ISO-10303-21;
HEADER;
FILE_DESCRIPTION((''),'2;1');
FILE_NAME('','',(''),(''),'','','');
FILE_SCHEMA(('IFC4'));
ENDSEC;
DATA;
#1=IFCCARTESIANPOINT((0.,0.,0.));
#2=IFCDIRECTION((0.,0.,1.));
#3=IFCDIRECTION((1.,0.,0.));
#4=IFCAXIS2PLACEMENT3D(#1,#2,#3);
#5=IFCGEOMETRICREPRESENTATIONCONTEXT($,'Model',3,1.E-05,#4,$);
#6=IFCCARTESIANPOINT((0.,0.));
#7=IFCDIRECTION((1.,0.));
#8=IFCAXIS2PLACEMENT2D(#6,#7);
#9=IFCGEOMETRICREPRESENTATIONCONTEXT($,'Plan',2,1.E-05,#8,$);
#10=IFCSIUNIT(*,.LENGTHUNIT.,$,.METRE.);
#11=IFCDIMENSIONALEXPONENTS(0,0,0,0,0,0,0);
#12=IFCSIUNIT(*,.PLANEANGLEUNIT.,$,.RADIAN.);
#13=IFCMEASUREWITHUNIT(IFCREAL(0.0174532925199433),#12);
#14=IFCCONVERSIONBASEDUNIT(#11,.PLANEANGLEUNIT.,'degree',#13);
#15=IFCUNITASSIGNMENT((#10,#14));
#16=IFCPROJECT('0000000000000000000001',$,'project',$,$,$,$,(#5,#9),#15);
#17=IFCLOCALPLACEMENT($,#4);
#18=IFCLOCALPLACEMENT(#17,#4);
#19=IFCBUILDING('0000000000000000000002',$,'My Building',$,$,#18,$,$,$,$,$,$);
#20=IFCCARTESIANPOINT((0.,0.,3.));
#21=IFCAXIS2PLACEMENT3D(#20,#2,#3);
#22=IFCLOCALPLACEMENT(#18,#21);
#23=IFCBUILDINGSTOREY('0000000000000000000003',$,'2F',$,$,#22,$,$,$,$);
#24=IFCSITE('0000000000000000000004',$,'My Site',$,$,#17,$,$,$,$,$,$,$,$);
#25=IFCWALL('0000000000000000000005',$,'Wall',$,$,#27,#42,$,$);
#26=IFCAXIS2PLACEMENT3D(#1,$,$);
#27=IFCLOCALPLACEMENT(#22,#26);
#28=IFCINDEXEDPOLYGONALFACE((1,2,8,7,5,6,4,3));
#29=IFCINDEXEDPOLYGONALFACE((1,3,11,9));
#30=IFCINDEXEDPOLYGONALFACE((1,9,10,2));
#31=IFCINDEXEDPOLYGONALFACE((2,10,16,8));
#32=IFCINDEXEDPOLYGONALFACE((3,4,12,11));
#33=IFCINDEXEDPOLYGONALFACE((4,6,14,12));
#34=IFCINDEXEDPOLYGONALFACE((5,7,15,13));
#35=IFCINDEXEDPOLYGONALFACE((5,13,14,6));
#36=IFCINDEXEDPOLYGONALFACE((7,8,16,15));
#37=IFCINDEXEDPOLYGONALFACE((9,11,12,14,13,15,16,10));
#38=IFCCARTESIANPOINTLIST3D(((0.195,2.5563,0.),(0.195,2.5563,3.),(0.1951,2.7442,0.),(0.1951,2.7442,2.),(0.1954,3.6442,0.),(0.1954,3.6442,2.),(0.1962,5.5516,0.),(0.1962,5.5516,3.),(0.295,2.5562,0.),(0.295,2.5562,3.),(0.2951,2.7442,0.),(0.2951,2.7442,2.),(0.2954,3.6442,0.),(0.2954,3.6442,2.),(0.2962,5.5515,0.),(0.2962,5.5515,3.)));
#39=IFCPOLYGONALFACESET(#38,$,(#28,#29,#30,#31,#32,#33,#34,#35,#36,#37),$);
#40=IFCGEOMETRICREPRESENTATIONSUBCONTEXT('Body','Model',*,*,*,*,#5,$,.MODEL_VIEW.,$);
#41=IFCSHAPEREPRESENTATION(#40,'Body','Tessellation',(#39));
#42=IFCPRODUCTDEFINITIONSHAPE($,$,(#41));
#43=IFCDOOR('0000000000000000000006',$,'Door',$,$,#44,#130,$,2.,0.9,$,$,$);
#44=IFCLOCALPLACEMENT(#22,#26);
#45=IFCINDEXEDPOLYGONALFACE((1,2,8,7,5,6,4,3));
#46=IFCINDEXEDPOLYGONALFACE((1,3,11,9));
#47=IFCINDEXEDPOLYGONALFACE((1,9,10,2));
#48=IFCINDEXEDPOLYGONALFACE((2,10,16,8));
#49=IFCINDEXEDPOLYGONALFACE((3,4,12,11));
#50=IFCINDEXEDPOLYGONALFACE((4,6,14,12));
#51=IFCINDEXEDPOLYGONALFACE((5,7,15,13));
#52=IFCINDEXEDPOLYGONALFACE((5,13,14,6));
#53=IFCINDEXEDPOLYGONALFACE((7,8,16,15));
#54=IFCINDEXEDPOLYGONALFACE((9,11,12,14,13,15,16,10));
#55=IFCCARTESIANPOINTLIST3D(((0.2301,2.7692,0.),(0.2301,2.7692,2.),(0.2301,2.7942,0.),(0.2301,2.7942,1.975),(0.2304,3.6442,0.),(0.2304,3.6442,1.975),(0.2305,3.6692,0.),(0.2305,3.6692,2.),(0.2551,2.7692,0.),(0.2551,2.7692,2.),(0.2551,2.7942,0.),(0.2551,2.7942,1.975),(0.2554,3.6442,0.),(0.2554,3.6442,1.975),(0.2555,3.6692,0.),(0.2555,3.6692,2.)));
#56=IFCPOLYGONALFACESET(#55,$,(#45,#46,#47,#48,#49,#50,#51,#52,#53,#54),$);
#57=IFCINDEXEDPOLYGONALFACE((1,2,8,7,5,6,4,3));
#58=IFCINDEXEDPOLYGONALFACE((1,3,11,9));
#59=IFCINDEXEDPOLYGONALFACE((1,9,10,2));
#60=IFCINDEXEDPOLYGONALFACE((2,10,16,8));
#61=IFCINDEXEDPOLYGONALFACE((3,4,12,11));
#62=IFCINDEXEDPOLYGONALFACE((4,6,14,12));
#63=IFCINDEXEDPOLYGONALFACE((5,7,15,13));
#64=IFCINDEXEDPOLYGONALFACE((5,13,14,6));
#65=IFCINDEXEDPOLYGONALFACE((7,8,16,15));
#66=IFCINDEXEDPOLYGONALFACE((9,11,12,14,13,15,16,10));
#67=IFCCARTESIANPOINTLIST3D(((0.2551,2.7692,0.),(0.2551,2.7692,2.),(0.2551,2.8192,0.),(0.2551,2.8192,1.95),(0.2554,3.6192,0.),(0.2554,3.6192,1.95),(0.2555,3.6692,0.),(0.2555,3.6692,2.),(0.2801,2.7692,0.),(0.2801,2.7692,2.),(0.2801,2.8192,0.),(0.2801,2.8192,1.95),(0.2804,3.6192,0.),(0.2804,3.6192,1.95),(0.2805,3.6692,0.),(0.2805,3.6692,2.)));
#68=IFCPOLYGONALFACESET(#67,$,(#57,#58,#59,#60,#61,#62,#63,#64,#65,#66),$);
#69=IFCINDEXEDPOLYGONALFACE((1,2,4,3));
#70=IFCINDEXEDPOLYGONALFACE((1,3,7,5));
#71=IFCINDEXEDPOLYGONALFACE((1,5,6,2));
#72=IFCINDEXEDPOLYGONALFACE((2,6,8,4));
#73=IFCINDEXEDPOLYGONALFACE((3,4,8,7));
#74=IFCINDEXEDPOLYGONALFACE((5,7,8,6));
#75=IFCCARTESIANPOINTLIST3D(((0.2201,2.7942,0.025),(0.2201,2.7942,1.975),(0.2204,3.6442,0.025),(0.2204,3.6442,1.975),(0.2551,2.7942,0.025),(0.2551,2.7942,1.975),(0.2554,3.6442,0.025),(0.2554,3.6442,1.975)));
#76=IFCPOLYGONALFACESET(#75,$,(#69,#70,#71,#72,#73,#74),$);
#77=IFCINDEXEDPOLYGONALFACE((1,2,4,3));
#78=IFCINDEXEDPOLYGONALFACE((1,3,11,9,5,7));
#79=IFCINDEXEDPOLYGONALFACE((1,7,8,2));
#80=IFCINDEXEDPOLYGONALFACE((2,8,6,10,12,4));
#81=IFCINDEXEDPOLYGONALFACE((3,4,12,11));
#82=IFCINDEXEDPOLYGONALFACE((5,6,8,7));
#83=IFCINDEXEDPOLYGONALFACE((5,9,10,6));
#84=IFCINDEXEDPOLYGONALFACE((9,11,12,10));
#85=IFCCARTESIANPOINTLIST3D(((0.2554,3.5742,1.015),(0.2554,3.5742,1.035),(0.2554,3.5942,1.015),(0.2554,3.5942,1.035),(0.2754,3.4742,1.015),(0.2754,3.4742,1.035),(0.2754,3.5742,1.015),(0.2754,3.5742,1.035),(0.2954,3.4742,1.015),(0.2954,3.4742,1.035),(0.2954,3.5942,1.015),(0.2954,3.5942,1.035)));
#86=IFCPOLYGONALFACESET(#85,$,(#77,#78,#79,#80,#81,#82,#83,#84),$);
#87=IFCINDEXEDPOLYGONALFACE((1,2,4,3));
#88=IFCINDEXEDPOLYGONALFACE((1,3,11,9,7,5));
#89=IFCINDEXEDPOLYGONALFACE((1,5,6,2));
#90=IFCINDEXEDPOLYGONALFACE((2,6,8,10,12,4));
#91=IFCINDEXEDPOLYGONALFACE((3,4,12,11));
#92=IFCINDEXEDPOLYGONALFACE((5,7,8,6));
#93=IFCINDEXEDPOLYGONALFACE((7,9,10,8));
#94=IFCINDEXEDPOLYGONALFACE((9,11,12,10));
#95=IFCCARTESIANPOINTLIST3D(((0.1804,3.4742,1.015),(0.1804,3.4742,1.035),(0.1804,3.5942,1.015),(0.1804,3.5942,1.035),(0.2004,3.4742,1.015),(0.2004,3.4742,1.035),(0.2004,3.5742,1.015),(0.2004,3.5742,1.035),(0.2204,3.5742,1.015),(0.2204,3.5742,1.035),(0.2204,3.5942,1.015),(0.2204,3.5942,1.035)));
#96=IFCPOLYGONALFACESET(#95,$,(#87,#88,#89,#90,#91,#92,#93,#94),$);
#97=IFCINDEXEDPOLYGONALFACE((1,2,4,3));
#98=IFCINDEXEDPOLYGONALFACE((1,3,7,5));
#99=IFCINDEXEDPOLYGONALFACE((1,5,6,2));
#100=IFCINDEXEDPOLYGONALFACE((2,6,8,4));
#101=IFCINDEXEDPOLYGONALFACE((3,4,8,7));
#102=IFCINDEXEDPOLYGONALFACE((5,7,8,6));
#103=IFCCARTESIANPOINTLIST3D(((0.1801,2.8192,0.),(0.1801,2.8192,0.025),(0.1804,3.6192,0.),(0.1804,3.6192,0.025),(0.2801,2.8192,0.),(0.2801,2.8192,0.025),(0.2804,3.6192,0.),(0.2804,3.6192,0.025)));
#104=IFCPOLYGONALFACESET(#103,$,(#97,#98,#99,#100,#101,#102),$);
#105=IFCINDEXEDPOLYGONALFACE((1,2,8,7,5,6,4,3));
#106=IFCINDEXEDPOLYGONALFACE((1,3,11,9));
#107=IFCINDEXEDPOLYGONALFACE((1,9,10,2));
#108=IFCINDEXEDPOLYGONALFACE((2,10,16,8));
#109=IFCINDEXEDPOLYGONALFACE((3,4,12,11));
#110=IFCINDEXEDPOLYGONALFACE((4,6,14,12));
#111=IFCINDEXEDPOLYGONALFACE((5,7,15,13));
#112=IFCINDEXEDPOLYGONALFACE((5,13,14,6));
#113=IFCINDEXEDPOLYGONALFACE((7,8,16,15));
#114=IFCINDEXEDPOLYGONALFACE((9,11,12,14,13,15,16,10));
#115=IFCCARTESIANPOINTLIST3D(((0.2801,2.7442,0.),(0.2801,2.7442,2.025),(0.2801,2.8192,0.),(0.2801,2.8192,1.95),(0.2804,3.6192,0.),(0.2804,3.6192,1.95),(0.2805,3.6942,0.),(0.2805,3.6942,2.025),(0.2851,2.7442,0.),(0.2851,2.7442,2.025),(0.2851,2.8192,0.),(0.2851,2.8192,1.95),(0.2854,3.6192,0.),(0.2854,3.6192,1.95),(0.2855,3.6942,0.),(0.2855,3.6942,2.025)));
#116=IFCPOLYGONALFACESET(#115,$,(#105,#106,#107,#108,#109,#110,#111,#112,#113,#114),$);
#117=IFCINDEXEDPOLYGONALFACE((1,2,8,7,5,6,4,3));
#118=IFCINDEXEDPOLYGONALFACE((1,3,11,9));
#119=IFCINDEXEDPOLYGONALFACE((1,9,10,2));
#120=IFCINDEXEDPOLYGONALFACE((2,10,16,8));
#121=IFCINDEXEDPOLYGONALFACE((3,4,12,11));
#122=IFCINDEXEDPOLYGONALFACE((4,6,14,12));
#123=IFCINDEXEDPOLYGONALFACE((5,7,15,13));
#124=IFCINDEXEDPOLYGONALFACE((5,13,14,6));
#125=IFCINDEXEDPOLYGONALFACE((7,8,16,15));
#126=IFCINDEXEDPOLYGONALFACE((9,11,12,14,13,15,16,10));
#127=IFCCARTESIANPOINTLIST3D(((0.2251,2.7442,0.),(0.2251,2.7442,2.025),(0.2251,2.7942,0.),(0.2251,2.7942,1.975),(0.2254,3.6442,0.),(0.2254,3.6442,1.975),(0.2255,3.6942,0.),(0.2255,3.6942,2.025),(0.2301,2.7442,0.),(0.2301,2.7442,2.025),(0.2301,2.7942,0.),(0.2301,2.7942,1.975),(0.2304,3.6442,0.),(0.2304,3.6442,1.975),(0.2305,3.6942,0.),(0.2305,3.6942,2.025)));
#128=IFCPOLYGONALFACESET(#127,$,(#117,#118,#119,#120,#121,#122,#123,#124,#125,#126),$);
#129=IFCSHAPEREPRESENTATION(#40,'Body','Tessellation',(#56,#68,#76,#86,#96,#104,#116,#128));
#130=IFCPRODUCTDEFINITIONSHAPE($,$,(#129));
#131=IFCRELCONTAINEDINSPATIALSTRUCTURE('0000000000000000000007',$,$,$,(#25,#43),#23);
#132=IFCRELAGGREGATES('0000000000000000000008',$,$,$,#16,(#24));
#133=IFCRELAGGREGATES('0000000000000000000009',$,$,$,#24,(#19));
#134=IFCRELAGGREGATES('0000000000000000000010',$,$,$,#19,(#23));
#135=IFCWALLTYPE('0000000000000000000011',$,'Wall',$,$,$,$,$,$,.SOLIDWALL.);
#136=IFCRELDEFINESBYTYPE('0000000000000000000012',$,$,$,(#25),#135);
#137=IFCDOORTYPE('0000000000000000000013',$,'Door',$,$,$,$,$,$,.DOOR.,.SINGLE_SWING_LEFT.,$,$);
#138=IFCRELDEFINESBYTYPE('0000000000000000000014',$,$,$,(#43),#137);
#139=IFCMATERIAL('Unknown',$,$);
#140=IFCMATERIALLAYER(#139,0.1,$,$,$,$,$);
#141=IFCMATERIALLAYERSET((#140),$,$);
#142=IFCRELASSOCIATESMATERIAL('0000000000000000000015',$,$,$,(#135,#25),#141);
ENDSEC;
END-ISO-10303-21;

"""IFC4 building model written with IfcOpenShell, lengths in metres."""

from ifc_helpers import new_model, entity, si_unit, converted_unit, frame, origin_with_axes, origin_2d_with_axis, place, context, subcontext, project, spatial, line, indexed_curve, outline, extrude, shape, source, transform, mapped, material, layer, layer_set, layer_usage, type_object, type_shapes, element, fill, save


model = new_model("IFC4")

# Units and contexts
model_context = context("Model", 3, precision=1e-05, world=origin_with_axes())
plan_context = context("Plan", 2, precision=1e-05, world=origin_2d_with_axis())
body_context_1 = subcontext(model_context, "Body", "Model", "MODEL_VIEW")
body_context_2 = subcontext(plan_context, "Body", "Plan", "PLAN_VIEW")
ifc_project = project(units=[si_unit("LENGTHUNIT", "METRE"), converted_unit("PLANEANGLEUNIT", "degree", entity("IfcReal", 0.0174532925199433), si_unit("PLANEANGLEUNIT", "RADIAN"), dimensions=[0, 0, 0, 0, 0, 0, 0])], contexts=[model_context, plan_context])

# Site, building, storey
site_placement = place(None, origin_with_axes())
site = spatial("IfcSite", under=ifc_project, at=site_placement, Name="My Site")
building_placement = place(site_placement, origin_with_axes())
building = spatial("IfcBuilding", under=site, at=building_placement, Name="My Building")
storey_placement = place(building_placement, frame((0.0, 0.0, 3.0), z_axis=(0.0, 0.0, 1.0), x_axis=(1.0, 0.0, 0.0)))
storey = spatial("IfcBuildingStorey", under=building, at=storey_placement, Name="2F")

# Shared definitions
ifc_material = material(Name="Unknown")
ifc_layer = layer(ifc_material, 0.1)
ifc_layer_set = layer_set([ifc_layer])
wall_type = type_object("IfcWallType", Name="Wall", PredefinedType="SOLIDWALL", material=ifc_layer_set)

# Wall, opening, door
ifc_layer_usage_1 = layer_usage(ifc_layer_set, "AXIS2", "POSITIVE", 0.0)
wall_1_placement = place(storey_placement, frame((0.1962, 5.5516, 0.0), z_axis=(0.0, 0.0, 1.0), x_axis=(-0.000399, -1.0, 0.0)))
wall_1 = element("IfcWall", 1, at=wall_1_placement, inside=storey, type_object=wall_type, material=ifc_layer_usage_1, Name="Wall", context=body_context_1, shape_type="SweptSolid", body=[
    extrude(outline(indexed_curve([(0.0, 0.0), (0.0, 0.1), (2.9953, 0.1), (2.9953, 0.0)], segments=[line(1, 2, 3, 4, 1)])), origin_with_axes(), (0.0, 0.0, 1.0), 3.0),
])
shared_shape_1 = source(origin_with_axes(), body_context_1, "Body", "SweptSolid", [
    extrude(outline(indexed_curve([(0.0, 0.0), (0.9, 0.0), (0.9, 2.0), (0.0, 2.0)], segments=[line(1, 2, 3, 4, 1)])), frame((0.0, -0.6, 0.0), z_axis=(0.0, -1.0, 0.0), x_axis=(1.0, 0.0, 0.0)), (0.0, 0.0, -1.0), 1.2),
])
opening_1_placement = place(wall_1_placement, frame((1.9074, 0.0, 0.0), z_axis=(0.0, 0.0, 1.0), x_axis=(1.0, 0.0, 0.0)))
opening_1 = element("IfcOpeningElement", 2, at=opening_1_placement, cuts=wall_1, PredefinedType="OPENING", context=body_context_1, shape_type="MappedRepresentation", body=[
    mapped(shared_shape_1, transform((0.0, 0.0, 0.0), x_axis=(1.0, 0.0, 0.0), y_axis=(0.0, 1.0, 0.0), z_axis=(0.0, 0.0, 1.0), scale=1.0)),
])
door_type_1 = type_object("IfcDoorType", Name="Door", OperationType="SINGLE_SWING_LEFT", PredefinedType="DOOR")
shared_shape_2 = source(origin_with_axes(), body_context_1, "Body", "SweptSolid", [
    extrude(outline(indexed_curve([(0.0, 0.0), (0.0, 2.0), (0.9, 2.0), (0.9, 0.0), (0.875, 0.0), (0.875, 1.975), (0.025, 1.975), (0.025, 0.0)], segments=[line(1, 2, 3, 4, 5, 6, 7, 8, 1)])), frame((0.0, 0.025, 0.0), z_axis=(0.0, -1.0, 0.0), x_axis=(1.0, 0.0, 0.0)), (0.0, 0.0, -1.0), 0.025),
    extrude(outline(indexed_curve([(0.0, 0.0), (0.0, 2.0), (0.9, 2.0), (0.9, 0.0), (0.85, 0.0), (0.85, 1.95), (0.05, 1.95), (0.05, 0.0)], segments=[line(1, 2, 3, 4, 5, 6, 7, 8, 1)])), frame((0.0, 0.0, 0.0), z_axis=(0.0, -1.0, 0.0), x_axis=(1.0, 0.0, 0.0)), (0.0, 0.0, -1.0), 0.025),
    extrude(outline(indexed_curve([(0.0, 0.0), (0.85, 0.0), (0.85, 0.035), (0.0, 0.035)], segments=[line(1, 2, 3, 4, 1)])), frame((0.025, 0.025, 0.025), z_axis=(0.0, 0.0, 1.0), x_axis=(1.0, 0.0, 0.0)), (0.0, 0.0, 1.0), 1.95),
    extrude(outline(indexed_curve([(0.0, 0.0), (0.0, -0.04), (-0.12, -0.04), (-0.12, -0.02), (-0.02, -0.02), (-0.02, 0.0)], segments=[line(1, 2, 3, 4, 5, 6, 1)])), frame((0.825, 0.025, 1.015), z_axis=(0.0, 0.0, 1.0), x_axis=(1.0, 0.0, 0.0)), (0.0, 0.0, 1.0), 0.02),
    extrude(outline(indexed_curve([(0.0, 0.0), (0.0, 0.04), (-0.12, 0.04), (-0.12, 0.02), (-0.02, 0.02), (-0.02, 0.0)], segments=[line(1, 2, 3, 4, 5, 6, 1)])), frame((0.825, 0.06, 1.015), z_axis=(0.0, 0.0, 1.0), x_axis=(1.0, 0.0, 0.0)), (0.0, 0.0, 1.0), 0.02),
    extrude(outline(indexed_curve([(0.0, 0.0), (0.8, 0.0), (0.8, 0.1), (0.0, 0.1)], segments=[line(1, 2, 3, 4, 1)])), frame((0.05, 0.0, 0.0), z_axis=(0.0, 0.0, 1.0), x_axis=(1.0, 0.0, 0.0)), (0.0, 0.0, 1.0), 0.025),
    extrude(outline(indexed_curve([(0.0, 0.0), (0.0, 2.025), (0.95, 2.025), (0.95, 0.0), (0.875, 0.0), (0.875, 1.95), (0.075, 1.95), (0.075, 0.0)], segments=[line(1, 2, 3, 4, 5, 6, 7, 8, 1)])), frame((-0.025, -0.005, 0.0), z_axis=(0.0, -1.0, 0.0), x_axis=(1.0, 0.0, 0.0)), (0.0, 0.0, -1.0), 0.005),
    extrude(outline(indexed_curve([(0.0, 0.0), (0.0, 2.025), (0.95, 2.025), (0.95, 0.0), (0.9, 0.0), (0.9, 1.975), (0.05, 1.975), (0.05, 0.0)], segments=[line(1, 2, 3, 4, 5, 6, 7, 8, 1)])), frame((-0.025, 0.05, 0.0), z_axis=(0.0, -1.0, 0.0), x_axis=(1.0, 0.0, 0.0)), (0.0, 0.0, -1.0), 0.005),
])
shared_shape_3 = source(origin_with_axes(), body_context_2, "Body", "Curve2D", [
    entity("IfcIndexedPolyCurve", entity("IfcCartesianPointList2D", [[0.0, 0.0], [0.0, 0.05], [0.025, 0.05], [0.025, 0.025], [0.05, 0.025], [0.05, 0.0]]), [entity("IfcLineIndex", [1, 2, 3, 4, 5, 6, 1])]),
    entity("IfcIndexedPolyCurve", entity("IfcCartesianPointList2D", [[0.9, 0.0], [0.9, 0.05], [0.875, 0.05], [0.875, 0.025], [0.85, 0.025], [0.85, 0.0]]), [entity("IfcLineIndex", [1, 2, 3, 4, 5, 6, 1])]),
    entity("IfcTrimmedCurve", entity("IfcEllipse", entity("IfcAxis2Placement2D", entity("IfcCartesianPoint", [0.06, 0.05]), entity("IfcDirection", [1.0, 0.0])), 0.815, 0.85), [entity("IfcCartesianPoint", [0.875, 0.05])], [entity("IfcCartesianPoint", [0.06, 0.9])], True, "CARTESIAN"),
    entity("IfcIndexedPolyCurve", entity("IfcCartesianPointList2D", [[0.025, 0.05], [0.06, 0.05], [0.06, 0.9], [0.025, 0.9]]), [entity("IfcLineIndex", [1, 2, 3, 4, 1])]),
])
type_shapes(door_type_1, [shared_shape_2, shared_shape_3])
door_1_placement = place(opening_1_placement, frame((0.875, 0.085, 0.0), z_axis=(0.0, 0.0, 1.0), x_axis=(-1.0, 0.0, 0.0)))
door_1 = element("IfcDoor", 3, at=door_1_placement, inside=storey, type_object=door_type_1, Name="Door", OverallHeight=2.0, OverallWidth=0.9, shapes=[
    shape(body_context_1, "Body", "MappedRepresentation", [mapped(shared_shape_2, transform((0.0, 0.0, 0.0), x_axis=(1.0, 0.0, 0.0), y_axis=(0.0, 1.0, 0.0), z_axis=(0.0, 0.0, 1.0), scale=1.0))]),
    shape(body_context_2, "Body", "MappedRepresentation", [mapped(shared_shape_3, transform((0.0, 0.0, 0.0), x_axis=(1.0, 0.0, 0.0), y_axis=(0.0, 1.0, 0.0), z_axis=(0.0, 0.0, 1.0), scale=1.0))]),
])
fill(opening_1, door_1)

save(model, "model.ifc")
